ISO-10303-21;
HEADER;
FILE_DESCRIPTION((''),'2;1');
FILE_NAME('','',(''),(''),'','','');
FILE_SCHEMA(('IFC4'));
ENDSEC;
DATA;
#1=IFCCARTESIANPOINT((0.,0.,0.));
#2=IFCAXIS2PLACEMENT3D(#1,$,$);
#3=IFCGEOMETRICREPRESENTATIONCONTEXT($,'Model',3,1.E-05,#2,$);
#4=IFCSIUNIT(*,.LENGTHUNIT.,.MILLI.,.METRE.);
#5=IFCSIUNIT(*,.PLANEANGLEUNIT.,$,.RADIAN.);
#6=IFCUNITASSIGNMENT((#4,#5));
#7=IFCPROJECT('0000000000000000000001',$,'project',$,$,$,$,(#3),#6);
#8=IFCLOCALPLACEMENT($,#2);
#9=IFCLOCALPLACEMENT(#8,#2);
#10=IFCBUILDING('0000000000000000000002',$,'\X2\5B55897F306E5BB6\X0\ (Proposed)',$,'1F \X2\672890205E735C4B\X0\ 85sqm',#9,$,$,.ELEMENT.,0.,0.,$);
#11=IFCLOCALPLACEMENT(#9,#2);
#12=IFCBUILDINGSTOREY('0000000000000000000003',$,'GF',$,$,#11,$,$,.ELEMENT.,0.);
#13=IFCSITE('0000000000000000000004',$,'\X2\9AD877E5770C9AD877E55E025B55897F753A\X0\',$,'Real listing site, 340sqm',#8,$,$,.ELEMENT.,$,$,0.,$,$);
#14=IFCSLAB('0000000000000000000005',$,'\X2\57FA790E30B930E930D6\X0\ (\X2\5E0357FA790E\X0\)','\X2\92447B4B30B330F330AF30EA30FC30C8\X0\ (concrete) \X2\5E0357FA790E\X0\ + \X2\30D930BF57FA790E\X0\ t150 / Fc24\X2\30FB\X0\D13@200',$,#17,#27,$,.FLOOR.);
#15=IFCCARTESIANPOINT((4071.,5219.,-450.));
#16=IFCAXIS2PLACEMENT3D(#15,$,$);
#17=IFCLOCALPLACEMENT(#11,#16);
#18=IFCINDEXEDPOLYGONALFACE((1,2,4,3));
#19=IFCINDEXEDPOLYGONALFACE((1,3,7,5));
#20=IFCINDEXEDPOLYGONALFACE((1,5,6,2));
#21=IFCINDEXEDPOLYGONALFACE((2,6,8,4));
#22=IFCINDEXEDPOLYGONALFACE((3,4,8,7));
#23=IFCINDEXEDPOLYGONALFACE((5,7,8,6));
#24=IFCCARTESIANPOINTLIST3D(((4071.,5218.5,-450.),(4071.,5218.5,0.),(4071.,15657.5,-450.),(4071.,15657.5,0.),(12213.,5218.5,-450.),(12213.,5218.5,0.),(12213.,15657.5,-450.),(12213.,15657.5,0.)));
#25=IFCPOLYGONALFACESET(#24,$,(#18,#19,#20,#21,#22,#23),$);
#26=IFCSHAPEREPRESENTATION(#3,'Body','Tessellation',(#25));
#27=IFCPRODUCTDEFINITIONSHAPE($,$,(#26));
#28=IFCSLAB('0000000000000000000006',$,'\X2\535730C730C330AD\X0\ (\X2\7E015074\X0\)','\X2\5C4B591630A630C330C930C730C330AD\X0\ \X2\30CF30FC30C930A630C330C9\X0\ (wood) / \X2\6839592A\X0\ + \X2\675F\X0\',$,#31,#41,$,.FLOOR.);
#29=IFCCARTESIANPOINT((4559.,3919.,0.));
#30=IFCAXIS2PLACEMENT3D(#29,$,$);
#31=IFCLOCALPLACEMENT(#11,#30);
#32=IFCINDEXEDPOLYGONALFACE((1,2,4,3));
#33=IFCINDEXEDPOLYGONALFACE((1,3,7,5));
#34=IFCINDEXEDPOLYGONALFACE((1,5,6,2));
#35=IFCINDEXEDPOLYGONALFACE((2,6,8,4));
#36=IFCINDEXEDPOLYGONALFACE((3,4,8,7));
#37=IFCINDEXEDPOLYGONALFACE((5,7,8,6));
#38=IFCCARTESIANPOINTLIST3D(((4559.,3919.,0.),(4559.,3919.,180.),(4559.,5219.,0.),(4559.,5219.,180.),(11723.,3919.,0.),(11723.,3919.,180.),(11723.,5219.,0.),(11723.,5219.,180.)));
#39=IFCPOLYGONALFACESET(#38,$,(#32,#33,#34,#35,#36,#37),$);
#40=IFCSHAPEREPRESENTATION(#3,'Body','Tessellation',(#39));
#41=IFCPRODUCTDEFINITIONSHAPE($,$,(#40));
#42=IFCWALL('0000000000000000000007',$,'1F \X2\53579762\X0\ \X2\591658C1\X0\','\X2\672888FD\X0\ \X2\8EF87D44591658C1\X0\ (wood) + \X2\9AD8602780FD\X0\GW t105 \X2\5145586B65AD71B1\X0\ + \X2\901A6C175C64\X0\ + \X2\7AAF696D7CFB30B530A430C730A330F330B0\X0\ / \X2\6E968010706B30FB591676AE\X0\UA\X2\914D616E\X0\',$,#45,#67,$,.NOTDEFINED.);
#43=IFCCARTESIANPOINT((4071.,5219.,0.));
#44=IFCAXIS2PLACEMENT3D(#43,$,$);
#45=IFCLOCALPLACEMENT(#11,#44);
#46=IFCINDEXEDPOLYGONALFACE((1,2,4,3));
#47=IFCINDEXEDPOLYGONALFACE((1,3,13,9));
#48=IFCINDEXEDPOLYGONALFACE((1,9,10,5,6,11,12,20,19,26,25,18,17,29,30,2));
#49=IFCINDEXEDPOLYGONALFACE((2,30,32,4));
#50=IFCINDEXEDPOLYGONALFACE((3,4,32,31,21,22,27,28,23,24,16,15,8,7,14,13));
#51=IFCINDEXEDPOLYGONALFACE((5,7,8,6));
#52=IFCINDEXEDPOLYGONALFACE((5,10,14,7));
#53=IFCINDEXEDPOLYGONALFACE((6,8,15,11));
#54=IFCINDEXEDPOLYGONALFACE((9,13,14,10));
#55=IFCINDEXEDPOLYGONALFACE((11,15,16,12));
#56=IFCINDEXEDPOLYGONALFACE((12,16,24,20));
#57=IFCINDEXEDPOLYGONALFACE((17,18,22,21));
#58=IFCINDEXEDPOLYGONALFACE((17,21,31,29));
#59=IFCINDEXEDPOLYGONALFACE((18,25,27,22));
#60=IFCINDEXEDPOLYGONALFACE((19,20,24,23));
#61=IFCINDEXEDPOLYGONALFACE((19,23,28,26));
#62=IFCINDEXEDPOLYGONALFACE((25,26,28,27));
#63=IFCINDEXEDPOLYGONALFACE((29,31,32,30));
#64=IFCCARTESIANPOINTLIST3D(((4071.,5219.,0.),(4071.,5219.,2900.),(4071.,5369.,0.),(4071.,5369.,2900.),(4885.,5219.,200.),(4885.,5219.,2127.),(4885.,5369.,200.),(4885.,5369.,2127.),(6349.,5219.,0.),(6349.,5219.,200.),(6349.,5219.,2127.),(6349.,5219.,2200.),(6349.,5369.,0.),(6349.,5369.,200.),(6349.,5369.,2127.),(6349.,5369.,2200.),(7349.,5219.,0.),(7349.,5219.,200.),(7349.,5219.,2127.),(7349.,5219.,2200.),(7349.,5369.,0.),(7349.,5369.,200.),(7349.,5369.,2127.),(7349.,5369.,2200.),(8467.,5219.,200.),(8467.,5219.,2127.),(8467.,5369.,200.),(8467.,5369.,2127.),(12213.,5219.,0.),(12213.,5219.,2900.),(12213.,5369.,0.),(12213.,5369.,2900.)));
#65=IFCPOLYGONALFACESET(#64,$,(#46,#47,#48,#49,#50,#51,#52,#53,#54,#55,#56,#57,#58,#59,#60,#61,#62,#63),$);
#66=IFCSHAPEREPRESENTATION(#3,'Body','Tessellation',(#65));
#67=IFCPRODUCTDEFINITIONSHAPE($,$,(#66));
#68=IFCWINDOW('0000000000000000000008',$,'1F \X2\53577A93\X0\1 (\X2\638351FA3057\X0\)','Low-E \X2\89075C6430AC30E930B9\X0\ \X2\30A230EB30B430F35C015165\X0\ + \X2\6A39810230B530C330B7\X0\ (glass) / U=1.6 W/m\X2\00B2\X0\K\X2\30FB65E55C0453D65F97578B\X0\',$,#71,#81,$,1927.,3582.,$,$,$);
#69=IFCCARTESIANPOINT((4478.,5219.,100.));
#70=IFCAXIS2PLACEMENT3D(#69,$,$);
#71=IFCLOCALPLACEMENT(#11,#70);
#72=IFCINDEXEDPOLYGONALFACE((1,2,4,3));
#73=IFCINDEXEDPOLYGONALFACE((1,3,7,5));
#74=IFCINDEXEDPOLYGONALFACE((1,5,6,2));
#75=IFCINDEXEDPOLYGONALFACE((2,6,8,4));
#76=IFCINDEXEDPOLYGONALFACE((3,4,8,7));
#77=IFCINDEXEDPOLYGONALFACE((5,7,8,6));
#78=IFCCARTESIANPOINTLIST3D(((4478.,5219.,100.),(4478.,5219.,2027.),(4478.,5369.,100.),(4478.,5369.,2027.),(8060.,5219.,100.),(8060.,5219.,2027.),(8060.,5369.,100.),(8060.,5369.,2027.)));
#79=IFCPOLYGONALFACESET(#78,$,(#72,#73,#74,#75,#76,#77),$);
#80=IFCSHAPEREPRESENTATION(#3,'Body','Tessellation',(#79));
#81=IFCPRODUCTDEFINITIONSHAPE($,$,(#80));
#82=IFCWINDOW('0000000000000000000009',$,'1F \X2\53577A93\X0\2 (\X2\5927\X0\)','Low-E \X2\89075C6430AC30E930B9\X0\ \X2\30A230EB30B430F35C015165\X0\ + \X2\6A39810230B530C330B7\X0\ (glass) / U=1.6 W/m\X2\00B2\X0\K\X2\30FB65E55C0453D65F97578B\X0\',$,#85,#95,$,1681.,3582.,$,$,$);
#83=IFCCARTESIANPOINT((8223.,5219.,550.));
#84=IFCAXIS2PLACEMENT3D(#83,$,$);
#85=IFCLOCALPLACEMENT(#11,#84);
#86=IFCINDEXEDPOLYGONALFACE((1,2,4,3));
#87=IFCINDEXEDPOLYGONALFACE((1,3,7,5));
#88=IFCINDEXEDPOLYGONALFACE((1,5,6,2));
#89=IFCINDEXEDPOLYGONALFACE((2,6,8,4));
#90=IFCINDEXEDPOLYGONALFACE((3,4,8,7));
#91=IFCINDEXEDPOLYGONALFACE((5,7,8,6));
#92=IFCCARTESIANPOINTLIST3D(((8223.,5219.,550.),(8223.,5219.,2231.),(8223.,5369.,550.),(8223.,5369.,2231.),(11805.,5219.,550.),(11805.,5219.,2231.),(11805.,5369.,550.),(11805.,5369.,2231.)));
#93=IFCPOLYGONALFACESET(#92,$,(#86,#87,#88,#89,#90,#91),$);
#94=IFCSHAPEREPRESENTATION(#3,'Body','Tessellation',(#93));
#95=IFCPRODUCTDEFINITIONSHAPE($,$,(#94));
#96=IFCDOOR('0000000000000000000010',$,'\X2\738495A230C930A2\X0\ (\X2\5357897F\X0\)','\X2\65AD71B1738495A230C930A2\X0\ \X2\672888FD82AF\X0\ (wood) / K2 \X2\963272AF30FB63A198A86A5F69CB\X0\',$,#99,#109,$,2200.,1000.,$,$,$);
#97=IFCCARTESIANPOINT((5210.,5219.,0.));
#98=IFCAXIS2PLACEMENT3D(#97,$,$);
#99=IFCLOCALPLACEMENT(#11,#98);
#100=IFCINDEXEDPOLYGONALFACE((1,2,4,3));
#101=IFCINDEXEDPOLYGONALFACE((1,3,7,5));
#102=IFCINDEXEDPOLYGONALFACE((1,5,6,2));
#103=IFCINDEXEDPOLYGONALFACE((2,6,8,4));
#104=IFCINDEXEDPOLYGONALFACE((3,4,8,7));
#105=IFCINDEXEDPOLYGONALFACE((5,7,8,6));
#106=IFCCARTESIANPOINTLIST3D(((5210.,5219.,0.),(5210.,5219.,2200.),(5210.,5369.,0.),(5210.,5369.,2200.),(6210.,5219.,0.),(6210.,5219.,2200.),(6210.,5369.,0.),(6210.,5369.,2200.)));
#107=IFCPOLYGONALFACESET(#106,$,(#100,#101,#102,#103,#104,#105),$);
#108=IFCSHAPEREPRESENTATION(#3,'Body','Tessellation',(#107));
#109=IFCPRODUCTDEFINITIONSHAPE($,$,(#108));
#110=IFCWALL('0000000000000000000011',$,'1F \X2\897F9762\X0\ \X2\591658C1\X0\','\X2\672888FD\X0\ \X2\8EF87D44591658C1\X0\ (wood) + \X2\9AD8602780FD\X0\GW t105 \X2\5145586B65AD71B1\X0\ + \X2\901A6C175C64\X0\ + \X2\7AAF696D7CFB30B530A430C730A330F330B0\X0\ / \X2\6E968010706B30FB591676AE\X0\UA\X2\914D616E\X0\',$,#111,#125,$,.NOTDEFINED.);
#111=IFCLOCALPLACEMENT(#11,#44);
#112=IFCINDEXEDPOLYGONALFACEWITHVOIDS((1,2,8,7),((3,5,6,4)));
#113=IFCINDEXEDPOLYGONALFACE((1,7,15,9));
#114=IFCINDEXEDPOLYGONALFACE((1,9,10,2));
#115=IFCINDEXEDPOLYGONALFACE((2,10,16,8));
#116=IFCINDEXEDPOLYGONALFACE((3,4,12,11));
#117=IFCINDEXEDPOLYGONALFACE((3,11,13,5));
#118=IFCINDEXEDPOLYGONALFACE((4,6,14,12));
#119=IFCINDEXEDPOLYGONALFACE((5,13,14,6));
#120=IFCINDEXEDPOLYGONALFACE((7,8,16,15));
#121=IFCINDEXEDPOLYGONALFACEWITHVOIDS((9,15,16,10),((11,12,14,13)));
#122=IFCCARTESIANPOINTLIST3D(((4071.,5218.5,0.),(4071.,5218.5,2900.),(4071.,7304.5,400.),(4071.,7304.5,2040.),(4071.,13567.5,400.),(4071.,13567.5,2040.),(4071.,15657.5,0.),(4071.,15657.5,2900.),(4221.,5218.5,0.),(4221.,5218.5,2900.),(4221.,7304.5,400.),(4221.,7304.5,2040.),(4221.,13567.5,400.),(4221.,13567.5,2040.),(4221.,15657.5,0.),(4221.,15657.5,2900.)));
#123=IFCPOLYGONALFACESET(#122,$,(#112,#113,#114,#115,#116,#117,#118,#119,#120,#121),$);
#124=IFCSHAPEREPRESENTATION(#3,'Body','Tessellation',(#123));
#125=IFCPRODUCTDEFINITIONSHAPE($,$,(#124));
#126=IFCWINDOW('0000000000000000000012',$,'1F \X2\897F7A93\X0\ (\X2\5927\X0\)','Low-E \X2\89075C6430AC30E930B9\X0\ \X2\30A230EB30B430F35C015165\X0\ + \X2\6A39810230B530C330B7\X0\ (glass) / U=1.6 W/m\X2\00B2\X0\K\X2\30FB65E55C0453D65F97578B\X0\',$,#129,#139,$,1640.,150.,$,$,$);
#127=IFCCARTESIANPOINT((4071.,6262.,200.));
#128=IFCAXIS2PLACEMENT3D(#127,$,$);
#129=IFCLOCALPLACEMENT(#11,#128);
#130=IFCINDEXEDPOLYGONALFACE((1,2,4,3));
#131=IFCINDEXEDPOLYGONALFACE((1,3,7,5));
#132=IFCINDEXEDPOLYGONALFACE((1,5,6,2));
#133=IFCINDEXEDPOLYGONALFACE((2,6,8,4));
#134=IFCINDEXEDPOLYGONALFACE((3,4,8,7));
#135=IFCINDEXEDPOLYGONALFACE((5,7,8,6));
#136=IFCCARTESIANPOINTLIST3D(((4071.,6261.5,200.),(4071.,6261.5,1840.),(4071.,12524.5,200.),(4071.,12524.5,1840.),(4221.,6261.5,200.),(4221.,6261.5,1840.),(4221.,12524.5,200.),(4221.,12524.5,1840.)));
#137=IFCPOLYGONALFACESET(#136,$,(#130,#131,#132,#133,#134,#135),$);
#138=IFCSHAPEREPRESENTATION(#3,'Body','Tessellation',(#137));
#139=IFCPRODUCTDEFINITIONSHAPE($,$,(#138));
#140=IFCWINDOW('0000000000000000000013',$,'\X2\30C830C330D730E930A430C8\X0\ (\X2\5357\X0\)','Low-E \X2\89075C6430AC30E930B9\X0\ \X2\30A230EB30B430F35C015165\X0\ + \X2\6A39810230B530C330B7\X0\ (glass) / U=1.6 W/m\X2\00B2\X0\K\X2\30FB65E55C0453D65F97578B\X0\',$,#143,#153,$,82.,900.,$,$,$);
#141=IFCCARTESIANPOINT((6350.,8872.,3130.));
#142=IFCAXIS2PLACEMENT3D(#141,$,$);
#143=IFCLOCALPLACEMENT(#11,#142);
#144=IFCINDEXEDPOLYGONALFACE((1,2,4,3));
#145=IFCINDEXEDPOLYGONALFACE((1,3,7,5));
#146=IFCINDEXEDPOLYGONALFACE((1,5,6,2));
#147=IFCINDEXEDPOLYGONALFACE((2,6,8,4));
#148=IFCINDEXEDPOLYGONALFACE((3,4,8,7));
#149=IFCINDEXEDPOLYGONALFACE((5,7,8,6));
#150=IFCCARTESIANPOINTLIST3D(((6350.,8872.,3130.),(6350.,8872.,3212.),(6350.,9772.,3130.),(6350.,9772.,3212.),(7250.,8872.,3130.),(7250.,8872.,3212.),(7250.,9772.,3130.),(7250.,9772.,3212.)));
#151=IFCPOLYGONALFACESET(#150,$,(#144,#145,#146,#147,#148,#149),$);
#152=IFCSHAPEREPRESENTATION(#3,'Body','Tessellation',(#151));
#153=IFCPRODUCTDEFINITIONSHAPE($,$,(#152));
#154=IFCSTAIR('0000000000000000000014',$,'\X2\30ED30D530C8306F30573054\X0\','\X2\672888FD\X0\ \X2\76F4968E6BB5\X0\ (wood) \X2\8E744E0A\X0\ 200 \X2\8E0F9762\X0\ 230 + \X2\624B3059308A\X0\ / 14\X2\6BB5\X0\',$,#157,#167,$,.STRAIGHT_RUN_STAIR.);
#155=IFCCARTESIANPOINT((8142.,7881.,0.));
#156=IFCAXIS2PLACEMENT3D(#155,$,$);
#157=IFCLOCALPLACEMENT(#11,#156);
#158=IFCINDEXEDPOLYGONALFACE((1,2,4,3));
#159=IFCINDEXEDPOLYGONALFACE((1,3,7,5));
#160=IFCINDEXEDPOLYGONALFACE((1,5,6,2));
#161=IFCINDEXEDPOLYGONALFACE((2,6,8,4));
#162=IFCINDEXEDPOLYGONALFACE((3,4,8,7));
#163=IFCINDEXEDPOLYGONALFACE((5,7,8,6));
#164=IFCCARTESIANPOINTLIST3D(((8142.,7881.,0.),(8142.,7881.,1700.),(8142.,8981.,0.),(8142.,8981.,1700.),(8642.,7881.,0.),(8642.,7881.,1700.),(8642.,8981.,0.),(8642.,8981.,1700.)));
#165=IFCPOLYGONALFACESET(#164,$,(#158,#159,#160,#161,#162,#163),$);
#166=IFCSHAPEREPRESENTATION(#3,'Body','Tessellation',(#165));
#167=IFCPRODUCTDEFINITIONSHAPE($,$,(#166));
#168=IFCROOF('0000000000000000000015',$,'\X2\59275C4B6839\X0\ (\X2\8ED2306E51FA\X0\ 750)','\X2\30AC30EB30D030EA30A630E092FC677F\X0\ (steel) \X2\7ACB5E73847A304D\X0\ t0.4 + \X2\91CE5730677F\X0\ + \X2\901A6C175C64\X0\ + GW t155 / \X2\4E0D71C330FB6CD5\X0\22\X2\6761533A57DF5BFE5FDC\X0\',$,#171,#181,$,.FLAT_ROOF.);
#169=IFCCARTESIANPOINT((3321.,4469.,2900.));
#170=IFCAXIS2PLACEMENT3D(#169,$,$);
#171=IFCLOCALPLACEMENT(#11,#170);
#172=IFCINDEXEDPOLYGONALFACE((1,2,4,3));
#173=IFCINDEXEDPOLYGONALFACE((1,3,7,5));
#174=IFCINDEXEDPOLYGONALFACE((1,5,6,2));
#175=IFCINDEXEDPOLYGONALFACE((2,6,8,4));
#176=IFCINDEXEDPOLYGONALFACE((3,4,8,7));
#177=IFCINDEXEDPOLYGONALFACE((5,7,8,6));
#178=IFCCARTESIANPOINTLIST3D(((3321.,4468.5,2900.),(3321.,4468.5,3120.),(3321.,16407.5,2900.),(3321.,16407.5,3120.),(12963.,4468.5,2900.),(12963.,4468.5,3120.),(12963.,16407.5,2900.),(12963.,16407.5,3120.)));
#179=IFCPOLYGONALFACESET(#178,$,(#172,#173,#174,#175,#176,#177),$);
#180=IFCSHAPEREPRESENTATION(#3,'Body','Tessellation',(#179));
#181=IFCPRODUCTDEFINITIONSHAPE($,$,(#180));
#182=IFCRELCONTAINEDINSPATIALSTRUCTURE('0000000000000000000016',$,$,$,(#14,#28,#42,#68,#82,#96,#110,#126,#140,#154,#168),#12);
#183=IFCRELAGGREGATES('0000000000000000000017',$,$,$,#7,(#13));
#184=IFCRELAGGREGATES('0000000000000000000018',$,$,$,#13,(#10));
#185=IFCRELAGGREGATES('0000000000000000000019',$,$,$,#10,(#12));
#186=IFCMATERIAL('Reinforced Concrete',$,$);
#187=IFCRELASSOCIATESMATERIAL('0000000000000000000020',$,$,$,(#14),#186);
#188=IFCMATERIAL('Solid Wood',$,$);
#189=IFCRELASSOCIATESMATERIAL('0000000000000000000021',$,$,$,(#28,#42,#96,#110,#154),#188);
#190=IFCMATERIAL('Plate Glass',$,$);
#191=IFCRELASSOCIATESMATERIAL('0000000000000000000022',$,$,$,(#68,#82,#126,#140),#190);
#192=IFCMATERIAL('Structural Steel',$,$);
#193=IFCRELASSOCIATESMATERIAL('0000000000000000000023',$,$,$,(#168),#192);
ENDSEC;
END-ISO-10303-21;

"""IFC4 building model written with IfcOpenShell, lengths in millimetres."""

from ifc_helpers import new_model, si_unit, frame, frame_2d, origin, place, context, project, spatial, rectangle, extrude, material, element, fill, save


model = new_model("IFC4")

# Units and contexts
model_context = context("Model", 3, precision=1e-05, world=origin())
ifc_project = project(units=[si_unit("LENGTHUNIT", "METRE", prefix="MILLI"), si_unit("PLANEANGLEUNIT", "RADIAN")], contexts=[model_context])

# Site, building, storey
site_placement = place(None, origin())
site = spatial("IfcSite", under=ifc_project, at=site_placement, Name="高知県高知市孕西町", ObjectType="Real listing site, 340sqm", CompositionType="ELEMENT", RefElevation=0.0)
building_placement = place(site_placement, origin())
building = spatial("IfcBuilding", under=site, at=building_placement, Name="孕西の家 (Proposed)", ObjectType="1F 木造平屋 85sqm", CompositionType="ELEMENT", ElevationOfRefHeight=0.0, ElevationOfTerrain=0.0)
storey_placement = place(building_placement, origin())
storey = spatial("IfcBuildingStorey", under=building, at=storey_placement, Name="GF", CompositionType="ELEMENT", Elevation=0.0)

# Slabs
ifc_material_1 = material(Name="Reinforced Concrete")
slab_1_placement = place(storey_placement, frame((4071.0, 5219.0, -450.0)))
element("IfcSlab", 1, at=slab_1_placement, inside=storey, material=ifc_material_1, Name="基礎スラブ (布基礎)", Description="鉄筋コンクリート (concrete) 布基礎 + ベタ基礎 t150 / Fc24・D13@200", PredefinedType="FLOOR", context=model_context, shape_type="SweptSolid", body=[
    extrude(rectangle(XDim=8142.0, YDim=10439.0, at=frame_2d((4071.0, 5219.0))), frame((4071.0, 5219.0, -450.0)), (0.0, 0.0, 1.0), 450.0),
])
ifc_material_2 = material(Name="Solid Wood")
slab_2_placement = place(storey_placement, frame((4559.0, 3919.0, 0.0)))
element("IfcSlab", 2, at=slab_2_placement, inside=storey, material=ifc_material_2, Name="南デッキ (縁側)", Description="屋外ウッドデッキ ハードウッド (wood) / 根太 + 束", PredefinedType="FLOOR", context=model_context, shape_type="SweptSolid", body=[
    extrude(rectangle(XDim=7164.0, YDim=1300.0, at=frame_2d((3582.0, 650.0))), frame((4559.0, 3919.0, 0.0)), (0.0, 0.0, 1.0), 180.0),
])

# Wall, openings, windows, door
wall_1_placement = place(storey_placement, frame((4071.0, 5219.0, 0.0)))
wall_1 = element("IfcWall", 3, at=wall_1_placement, inside=storey, material=ifc_material_2, Name="1F 南面 外壁", Description="木製 軸組外壁 (wood) + 高性能GW t105 充填断熱 + 通気層 + 窯業系サイディング / 準耐火・外皮UA配慮", PredefinedType="NOTDEFINED", context=model_context, shape_type="SweptSolid", body=[
    extrude(rectangle(XDim=8142.0, YDim=150.0, at=frame_2d((4071.0, 75.0))), frame((4071.0, 5219.0, 0.0)), (0.0, 0.0, 1.0), 2900.0),
])
opening_1_placement = place(storey_placement, frame((4478.0, 5219.0, 100.0)))
opening_1 = element("IfcOpeningElement", 4, at=opening_1_placement, cuts=wall_1, PredefinedType="NOTDEFINED", context=model_context, shape_type="SweptSolid", body=[
    extrude(rectangle(XDim=3582.0, YDim=150.0, at=frame_2d((1791.0, 75.0))), frame((4478.0, 5219.0, 100.0)), (0.0, 0.0, 1.0), 1927.0),
])
opening_2_placement = place(storey_placement, frame((8223.0, 5219.0, 550.0)))
opening_2 = element("IfcOpeningElement", 5, at=opening_2_placement, cuts=wall_1, PredefinedType="NOTDEFINED", context=model_context, shape_type="SweptSolid", body=[
    extrude(rectangle(XDim=3582.0, YDim=150.0, at=frame_2d((1791.0, 75.0))), frame((8223.0, 5219.0, 550.0)), (0.0, 0.0, 1.0), 1681.0),
])
opening_3_placement = place(storey_placement, frame((5210.0, 5219.0, 0.0)))
opening_3 = element("IfcOpeningElement", 6, at=opening_3_placement, cuts=wall_1, PredefinedType="NOTDEFINED", context=model_context, shape_type="SweptSolid", body=[
    extrude(rectangle(XDim=1000.0, YDim=150.0, at=frame_2d((500.0, 75.0))), frame((5210.0, 5219.0, 0.0)), (0.0, 0.0, 1.0), 2200.0),
])
ifc_material_3 = material(Name="Plate Glass")
window_1_placement = place(storey_placement, frame((4478.0, 5219.0, 100.0)))
window_1 = element("IfcWindow", 7, at=window_1_placement, inside=storey, material=ifc_material_3, Name="1F 南窓1 (掃出し)", Description="Low-E 複層ガラス アルゴン封入 + 樹脂サッシ (glass) / U=1.6 W/m²K・日射取得型", OverallHeight=1927.0, OverallWidth=3582.0, context=model_context, shape_type="SweptSolid", body=[
    extrude(rectangle(XDim=3582.0, YDim=150.0, at=frame_2d((1791.0, 75.0))), frame((4478.0, 5219.0, 100.0)), (0.0, 0.0, 1.0), 1927.0),
])
fill(opening_1, window_1)
window_2_placement = place(storey_placement, frame((8223.0, 5219.0, 550.0)))
window_2 = element("IfcWindow", 8, at=window_2_placement, inside=storey, material=ifc_material_3, Name="1F 南窓2 (大)", Description="Low-E 複層ガラス アルゴン封入 + 樹脂サッシ (glass) / U=1.6 W/m²K・日射取得型", OverallHeight=1681.0, OverallWidth=3582.0, context=model_context, shape_type="SweptSolid", body=[
    extrude(rectangle(XDim=3582.0, YDim=150.0, at=frame_2d((1791.0, 75.0))), frame((8223.0, 5219.0, 550.0)), (0.0, 0.0, 1.0), 1681.0),
])
fill(opening_2, window_2)
door_placement = place(storey_placement, frame((5210.0, 5219.0, 0.0)))
door = element("IfcDoor", 9, at=door_placement, inside=storey, material=ifc_material_2, Name="玄関ドア (南西)", Description="断熱玄関ドア 木製芯 (wood) / K2 防犯・採風機構", OverallHeight=2200.0, OverallWidth=1000.0, context=model_context, shape_type="SweptSolid", body=[
    extrude(rectangle(XDim=1000.0, YDim=150.0, at=frame_2d((500.0, 75.0))), frame((5210.0, 5219.0, 0.0)), (0.0, 0.0, 1.0), 2200.0),
])
fill(opening_3, door)

# Wall, opening, window
wall_2_placement = place(storey_placement, frame((4071.0, 5219.0, 0.0)))
wall_2 = element("IfcWall", 10, at=wall_2_placement, inside=storey, material=ifc_material_2, Name="1F 西面 外壁", Description="木製 軸組外壁 (wood) + 高性能GW t105 充填断熱 + 通気層 + 窯業系サイディング / 準耐火・外皮UA配慮", PredefinedType="NOTDEFINED", context=model_context, shape_type="SweptSolid", body=[
    extrude(rectangle(XDim=150.0, YDim=10439.0, at=frame_2d((75.0, 5219.0))), frame((4071.0, 5219.0, 0.0)), (0.0, 0.0, 1.0), 2900.0),
])
opening_4_placement = place(storey_placement, frame((4071.0, 6262.0, 200.0)))
opening_4 = element("IfcOpeningElement", 11, at=opening_4_placement, cuts=wall_2, PredefinedType="NOTDEFINED", context=model_context, shape_type="SweptSolid", body=[
    extrude(rectangle(XDim=150.0, YDim=6263.0, at=frame_2d((75.0, 3131.0))), frame((4071.0, 6262.0, 200.0)), (0.0, 0.0, 1.0), 1640.0),
])
window_3_placement = place(storey_placement, frame((4071.0, 6262.0, 200.0)))
window_3 = element("IfcWindow", 12, at=window_3_placement, inside=storey, material=ifc_material_3, Name="1F 西窓 (大)", Description="Low-E 複層ガラス アルゴン封入 + 樹脂サッシ (glass) / U=1.6 W/m²K・日射取得型", OverallHeight=1640.0, OverallWidth=150.0, context=model_context, shape_type="SweptSolid", body=[
    extrude(rectangle(XDim=150.0, YDim=6263.0, at=frame_2d((75.0, 3131.0))), frame((4071.0, 6262.0, 200.0)), (0.0, 0.0, 1.0), 1640.0),
])
fill(opening_4, window_3)

# Window
window_4_placement = place(storey_placement, frame((6350.0, 8872.0, 3130.0)))
element("IfcWindow", 13, at=window_4_placement, inside=storey, material=ifc_material_3, Name="トップライト (南)", Description="Low-E 複層ガラス アルゴン封入 + 樹脂サッシ (glass) / U=1.6 W/m²K・日射取得型", OverallHeight=82.0, OverallWidth=900.0, context=model_context, shape_type="SweptSolid", body=[
    extrude(rectangle(XDim=900.0, YDim=900.0, at=frame_2d((450.0, 450.0))), frame((6350.0, 8872.0, 3130.0)), (0.0, 0.0, 1.0), 82.0),
])

# Stair
stair_placement = place(storey_placement, frame((8142.0, 7881.0, 0.0)))
element("IfcStair", 14, at=stair_placement, inside=storey, material=ifc_material_2, Name="ロフトはしご", Description="木製 直階段 (wood) 蹴上 200 踏面 230 + 手すり / 14段", PredefinedType="STRAIGHT_RUN_STAIR", context=model_context, shape_type="SweptSolid", body=[
    extrude(rectangle(XDim=500.0, YDim=1100.0, at=frame_2d((250.0, 550.0))), frame((8142.0, 7881.0, 0.0)), (0.0, 0.0, 1.0), 1700.0),
])

# Roof
ifc_material_4 = material(Name="Structural Steel")
roof_placement = place(storey_placement, frame((3321.0, 4469.0, 2900.0)))
element("IfcRoof", 15, at=roof_placement, inside=storey, material=ifc_material_4, Name="大屋根 (軒の出 750)", Description="ガルバリウム鋼板 (steel) 立平葺き t0.4 + 野地板 + 通気層 + GW t155 / 不燃・法22条区域対応", PredefinedType="FLAT_ROOF", context=model_context, shape_type="SweptSolid", body=[
    extrude(rectangle(XDim=9642.0, YDim=11939.0, at=frame_2d((4821.0, 5969.0))), frame((3321.0, 4469.0, 2900.0)), (0.0, 0.0, 1.0), 220.0),
])

save(model, "model.ifc")
